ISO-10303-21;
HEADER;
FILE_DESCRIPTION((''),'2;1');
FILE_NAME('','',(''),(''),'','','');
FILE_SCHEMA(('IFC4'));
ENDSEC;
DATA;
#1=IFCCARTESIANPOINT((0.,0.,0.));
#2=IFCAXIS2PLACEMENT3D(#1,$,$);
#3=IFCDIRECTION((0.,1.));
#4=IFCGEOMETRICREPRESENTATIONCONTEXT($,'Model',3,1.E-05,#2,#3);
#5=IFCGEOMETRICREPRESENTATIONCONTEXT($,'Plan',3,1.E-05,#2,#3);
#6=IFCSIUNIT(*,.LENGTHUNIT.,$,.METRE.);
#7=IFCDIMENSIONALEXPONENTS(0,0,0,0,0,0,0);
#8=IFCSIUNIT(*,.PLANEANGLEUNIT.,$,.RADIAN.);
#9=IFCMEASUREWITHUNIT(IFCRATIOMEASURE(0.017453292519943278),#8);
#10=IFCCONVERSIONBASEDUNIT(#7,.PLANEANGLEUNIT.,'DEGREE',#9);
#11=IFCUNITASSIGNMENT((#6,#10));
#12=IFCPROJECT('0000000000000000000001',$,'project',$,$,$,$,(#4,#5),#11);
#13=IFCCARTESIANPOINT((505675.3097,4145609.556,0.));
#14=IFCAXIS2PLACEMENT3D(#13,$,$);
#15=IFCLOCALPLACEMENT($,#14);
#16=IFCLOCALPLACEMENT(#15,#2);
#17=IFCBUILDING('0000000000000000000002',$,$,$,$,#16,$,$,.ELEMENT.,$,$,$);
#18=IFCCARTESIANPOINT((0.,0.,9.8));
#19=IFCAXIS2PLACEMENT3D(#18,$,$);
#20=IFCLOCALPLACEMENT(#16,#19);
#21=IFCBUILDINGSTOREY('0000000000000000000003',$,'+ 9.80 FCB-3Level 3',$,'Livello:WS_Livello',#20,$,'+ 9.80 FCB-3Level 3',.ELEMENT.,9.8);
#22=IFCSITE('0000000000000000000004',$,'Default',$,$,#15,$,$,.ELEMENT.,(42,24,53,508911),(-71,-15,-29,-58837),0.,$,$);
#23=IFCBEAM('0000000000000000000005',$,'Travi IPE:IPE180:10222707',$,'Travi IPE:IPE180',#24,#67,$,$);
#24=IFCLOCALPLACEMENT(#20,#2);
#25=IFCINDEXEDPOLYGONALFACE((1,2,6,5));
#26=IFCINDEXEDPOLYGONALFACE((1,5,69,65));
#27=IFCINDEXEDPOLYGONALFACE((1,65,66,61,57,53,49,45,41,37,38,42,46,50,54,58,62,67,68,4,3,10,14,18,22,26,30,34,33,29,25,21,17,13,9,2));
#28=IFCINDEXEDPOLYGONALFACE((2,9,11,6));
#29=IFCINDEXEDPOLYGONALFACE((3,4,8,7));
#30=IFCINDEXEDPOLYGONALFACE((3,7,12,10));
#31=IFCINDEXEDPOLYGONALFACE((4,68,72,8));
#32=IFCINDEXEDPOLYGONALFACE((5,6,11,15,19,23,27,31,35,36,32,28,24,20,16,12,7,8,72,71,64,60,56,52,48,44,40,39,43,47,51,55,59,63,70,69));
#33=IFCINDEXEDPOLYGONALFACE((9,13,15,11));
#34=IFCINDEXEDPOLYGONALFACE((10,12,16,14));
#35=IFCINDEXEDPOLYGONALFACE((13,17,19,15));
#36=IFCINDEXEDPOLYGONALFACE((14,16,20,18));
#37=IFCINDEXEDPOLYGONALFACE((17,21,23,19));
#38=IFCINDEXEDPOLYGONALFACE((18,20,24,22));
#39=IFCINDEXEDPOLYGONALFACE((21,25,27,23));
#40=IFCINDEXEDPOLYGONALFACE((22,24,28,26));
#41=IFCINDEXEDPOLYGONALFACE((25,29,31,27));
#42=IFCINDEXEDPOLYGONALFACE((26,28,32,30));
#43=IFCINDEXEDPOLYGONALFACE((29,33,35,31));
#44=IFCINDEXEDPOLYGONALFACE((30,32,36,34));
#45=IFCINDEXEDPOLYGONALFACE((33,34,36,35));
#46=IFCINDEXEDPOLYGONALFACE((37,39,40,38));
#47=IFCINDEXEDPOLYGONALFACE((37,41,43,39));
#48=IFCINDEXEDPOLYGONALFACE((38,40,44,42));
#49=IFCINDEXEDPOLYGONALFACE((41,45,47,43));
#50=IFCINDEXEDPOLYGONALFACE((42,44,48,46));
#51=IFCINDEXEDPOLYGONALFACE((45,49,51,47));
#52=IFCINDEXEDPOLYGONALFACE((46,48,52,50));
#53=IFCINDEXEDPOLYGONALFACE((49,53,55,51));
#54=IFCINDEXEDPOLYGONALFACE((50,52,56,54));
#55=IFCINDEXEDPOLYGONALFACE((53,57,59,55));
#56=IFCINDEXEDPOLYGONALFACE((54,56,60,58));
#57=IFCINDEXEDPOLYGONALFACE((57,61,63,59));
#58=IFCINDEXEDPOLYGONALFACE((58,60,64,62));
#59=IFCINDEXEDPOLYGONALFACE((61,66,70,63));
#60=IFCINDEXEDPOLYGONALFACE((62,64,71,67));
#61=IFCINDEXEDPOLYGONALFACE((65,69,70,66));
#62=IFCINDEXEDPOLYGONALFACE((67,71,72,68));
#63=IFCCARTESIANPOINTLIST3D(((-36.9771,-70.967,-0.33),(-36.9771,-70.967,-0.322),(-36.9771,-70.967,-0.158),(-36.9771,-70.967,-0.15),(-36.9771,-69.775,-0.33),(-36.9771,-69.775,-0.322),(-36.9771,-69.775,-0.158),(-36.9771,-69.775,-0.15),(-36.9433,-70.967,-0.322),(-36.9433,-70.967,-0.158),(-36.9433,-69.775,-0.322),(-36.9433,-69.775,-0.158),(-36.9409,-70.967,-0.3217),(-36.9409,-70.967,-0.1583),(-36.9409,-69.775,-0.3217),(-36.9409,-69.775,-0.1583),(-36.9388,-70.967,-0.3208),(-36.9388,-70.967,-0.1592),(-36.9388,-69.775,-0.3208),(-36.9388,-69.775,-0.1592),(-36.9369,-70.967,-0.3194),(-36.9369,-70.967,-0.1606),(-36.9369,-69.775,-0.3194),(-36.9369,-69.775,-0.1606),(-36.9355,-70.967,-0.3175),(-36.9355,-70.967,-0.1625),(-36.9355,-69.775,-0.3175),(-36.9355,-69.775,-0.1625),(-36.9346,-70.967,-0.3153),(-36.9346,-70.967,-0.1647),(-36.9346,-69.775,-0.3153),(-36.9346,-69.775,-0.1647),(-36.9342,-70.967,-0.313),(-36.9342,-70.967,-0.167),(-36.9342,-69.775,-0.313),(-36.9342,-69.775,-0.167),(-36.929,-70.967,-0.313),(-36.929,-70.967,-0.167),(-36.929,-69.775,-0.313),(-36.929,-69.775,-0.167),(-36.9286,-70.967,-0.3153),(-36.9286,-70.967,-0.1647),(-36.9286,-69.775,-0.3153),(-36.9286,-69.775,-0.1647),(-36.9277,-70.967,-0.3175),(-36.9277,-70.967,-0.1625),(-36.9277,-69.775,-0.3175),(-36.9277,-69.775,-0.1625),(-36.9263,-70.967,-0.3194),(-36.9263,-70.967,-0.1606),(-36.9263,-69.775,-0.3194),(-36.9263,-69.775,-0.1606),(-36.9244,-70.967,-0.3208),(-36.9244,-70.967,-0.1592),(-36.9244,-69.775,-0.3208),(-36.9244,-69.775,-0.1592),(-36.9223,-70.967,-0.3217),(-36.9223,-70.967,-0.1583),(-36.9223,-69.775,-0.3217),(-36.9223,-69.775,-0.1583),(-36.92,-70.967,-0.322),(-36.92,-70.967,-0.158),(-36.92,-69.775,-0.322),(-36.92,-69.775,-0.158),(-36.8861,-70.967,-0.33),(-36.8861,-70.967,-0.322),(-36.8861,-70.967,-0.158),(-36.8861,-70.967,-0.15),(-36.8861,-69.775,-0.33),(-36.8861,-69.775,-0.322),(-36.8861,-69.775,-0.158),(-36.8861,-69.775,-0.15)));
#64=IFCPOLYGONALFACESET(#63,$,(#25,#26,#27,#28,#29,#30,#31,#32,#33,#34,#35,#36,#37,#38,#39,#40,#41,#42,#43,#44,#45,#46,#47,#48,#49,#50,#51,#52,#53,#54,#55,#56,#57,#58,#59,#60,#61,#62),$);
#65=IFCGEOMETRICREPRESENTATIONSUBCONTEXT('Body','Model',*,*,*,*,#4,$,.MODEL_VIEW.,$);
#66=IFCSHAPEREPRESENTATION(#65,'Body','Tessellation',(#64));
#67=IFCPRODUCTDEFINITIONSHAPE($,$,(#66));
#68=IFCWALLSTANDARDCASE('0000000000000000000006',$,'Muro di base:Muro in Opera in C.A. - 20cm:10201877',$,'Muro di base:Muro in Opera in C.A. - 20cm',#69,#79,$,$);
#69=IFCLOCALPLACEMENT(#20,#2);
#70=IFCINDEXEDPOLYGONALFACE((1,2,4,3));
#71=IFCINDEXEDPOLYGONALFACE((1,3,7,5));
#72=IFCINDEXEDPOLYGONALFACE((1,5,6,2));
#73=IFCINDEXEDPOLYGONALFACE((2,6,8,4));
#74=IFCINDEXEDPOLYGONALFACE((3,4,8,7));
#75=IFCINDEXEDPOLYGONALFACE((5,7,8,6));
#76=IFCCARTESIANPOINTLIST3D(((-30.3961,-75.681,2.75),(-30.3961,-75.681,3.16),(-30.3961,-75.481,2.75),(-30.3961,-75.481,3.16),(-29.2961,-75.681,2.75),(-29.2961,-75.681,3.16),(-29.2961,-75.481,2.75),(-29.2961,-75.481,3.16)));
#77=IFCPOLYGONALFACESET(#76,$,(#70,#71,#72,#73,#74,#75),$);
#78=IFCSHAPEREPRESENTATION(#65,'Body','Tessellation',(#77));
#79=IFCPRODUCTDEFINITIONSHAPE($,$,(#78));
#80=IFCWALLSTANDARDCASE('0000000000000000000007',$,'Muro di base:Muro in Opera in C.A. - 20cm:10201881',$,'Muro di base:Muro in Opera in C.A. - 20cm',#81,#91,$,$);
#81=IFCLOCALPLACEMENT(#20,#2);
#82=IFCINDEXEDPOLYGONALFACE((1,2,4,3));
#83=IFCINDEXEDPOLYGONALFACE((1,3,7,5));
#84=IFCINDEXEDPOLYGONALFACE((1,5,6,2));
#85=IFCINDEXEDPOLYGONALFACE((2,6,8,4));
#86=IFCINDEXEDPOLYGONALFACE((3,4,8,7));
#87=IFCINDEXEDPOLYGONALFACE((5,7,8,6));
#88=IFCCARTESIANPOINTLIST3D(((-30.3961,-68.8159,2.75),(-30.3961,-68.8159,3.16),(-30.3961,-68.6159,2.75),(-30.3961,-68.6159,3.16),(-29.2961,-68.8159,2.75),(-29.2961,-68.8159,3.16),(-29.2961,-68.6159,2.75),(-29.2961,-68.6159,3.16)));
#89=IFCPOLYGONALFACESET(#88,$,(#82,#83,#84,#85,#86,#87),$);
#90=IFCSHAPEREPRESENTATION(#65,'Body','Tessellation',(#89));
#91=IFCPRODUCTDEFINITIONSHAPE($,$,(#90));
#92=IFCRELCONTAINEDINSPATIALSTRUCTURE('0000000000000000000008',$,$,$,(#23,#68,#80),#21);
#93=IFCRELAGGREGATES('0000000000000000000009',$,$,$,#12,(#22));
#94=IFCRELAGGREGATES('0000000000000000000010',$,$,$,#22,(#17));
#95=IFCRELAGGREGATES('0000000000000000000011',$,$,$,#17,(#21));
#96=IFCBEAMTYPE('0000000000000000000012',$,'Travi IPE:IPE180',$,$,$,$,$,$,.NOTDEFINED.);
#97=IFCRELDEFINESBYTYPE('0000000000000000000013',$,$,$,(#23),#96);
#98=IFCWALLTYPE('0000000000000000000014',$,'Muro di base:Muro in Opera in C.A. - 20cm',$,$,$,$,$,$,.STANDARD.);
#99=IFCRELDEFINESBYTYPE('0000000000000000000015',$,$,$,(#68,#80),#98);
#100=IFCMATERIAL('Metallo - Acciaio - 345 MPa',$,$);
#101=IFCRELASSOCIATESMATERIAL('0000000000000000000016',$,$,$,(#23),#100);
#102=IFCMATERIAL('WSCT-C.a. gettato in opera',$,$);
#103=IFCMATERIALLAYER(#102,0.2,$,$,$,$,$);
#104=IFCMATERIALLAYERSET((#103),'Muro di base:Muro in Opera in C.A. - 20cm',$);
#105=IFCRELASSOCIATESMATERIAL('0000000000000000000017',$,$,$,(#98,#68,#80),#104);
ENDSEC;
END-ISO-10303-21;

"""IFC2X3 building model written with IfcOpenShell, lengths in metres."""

from ifc_helpers import new_model, entity, si_unit, converted_unit, direction, frame, frame_2d, origin, place, context, subcontext, project, spatial, rectangle, i_section, extrude, material, layer, layer_set, layer_usage, type_object, element, save


model = new_model("IFC2X3")

# Units and contexts
model_context = context("Model", 3, precision=1e-05, world=origin(), true_north=direction((0.0, 1.0)))
plan_context = context("Plan", 3, precision=1e-05, world=origin(), true_north=direction((0.0, 1.0)))
body_context = subcontext(model_context, "Body", "Model", "MODEL_VIEW")
ifc_project = project(units=[si_unit("LENGTHUNIT", "METRE"), converted_unit("PLANEANGLEUNIT", "DEGREE", entity("IfcRatioMeasure", 0.017453292519943278), si_unit("PLANEANGLEUNIT", "RADIAN"), dimensions=[0, 0, 0, 0, 0, 0, 0])], contexts=[model_context, plan_context])

# Site, building, storey
site_placement = place(None, frame((505675.3097, 4145609.556, 0.0)))
site = spatial("IfcSite", under=ifc_project, at=site_placement, Name="Default", CompositionType="ELEMENT", RefLatitude=(42, 24, 53, 508911), RefLongitude=(-71, -15, -29, -58837), RefElevation=0.0)
building_placement = place(site_placement, origin())
building = spatial("IfcBuilding", under=site, at=building_placement, CompositionType="ELEMENT")
storey_placement = place(building_placement, frame((0.0, 0.0, 9.8)))
storey = spatial("IfcBuildingStorey", under=building, at=storey_placement, Name="+ 9.80 FCB-3Level 3", ObjectType="Livello:WS_Livello", LongName="+ 9.80 FCB-3Level 3", CompositionType="ELEMENT", Elevation=9.8)

# Beam
ifc_material_1 = material(Name="Metallo - Acciaio - 345 MPa")
beam_type = type_object("IfcBeamType", Name="Travi IPE:IPE180", PredefinedType="NOTDEFINED")
beam_placement = place(storey_placement, frame((-36.9316, -69.7745, -0.15), z_axis=(0.0, 0.0, 1.0), x_axis=(0.0, -1.0, 0.0)))
element("IfcBeam", 1, at=beam_placement, inside=storey, type_object=beam_type, material=ifc_material_1, Name="Travi IPE:IPE180:10222707", ObjectType="Travi IPE:IPE180", context=body_context, shape_type="SweptSolid", body=[
    extrude(i_section(OverallWidth=0.091, OverallDepth=0.18, WebThickness=0.0053, FlangeThickness=0.008, FilletRadius=0.009, at=frame_2d((0.0, 0.0), x_axis=(0.0, 1.0))), frame((0.0005, 0.0, -0.09), z_axis=(1.0, 0.0, 0.0), x_axis=(0.0, 0.0, -1.0)), (0.0, 0.0, 1.0), 1.192),
])

# Walls
ifc_material_2 = material(Name="WSCT-C.a. gettato in opera")
ifc_layer_1 = layer(ifc_material_2, 0.2)
ifc_layer_set_1 = layer_set([ifc_layer_1], Name="Muro di base:Muro in Opera in C.A. - 20cm")
ifc_layer_usage_1 = layer_usage(ifc_layer_set_1, "AXIS2", "NEGATIVE", 0.1)
wall_type = type_object("IfcWallType", Name="Muro di base:Muro in Opera in C.A. - 20cm", PredefinedType="STANDARD", material=ifc_layer_set_1)
wall_1_placement = place(storey_placement, frame((-29.2961, -75.581, 2.75), z_axis=(0.0, 0.0, 1.0), x_axis=(-1.0, 0.0, 0.0)))
element("IfcWallStandardCase", 2, at=wall_1_placement, inside=storey, type_object=wall_type, material=ifc_layer_usage_1, Name="Muro di base:Muro in Opera in C.A. - 20cm:10201877", ObjectType="Muro di base:Muro in Opera in C.A. - 20cm", context=body_context, shape_type="SweptSolid", body=[
    extrude(rectangle(XDim=1.1, YDim=0.2, at=frame_2d((0.55, 0.0), x_axis=(-1.0, 0.0))), origin(), (0.0, 0.0, 1.0), 0.41),
])
wall_2_placement = place(storey_placement, frame((-30.3961, -68.7159, 2.75)))
element("IfcWallStandardCase", 3, at=wall_2_placement, inside=storey, type_object=wall_type, material=ifc_layer_usage_1, Name="Muro di base:Muro in Opera in C.A. - 20cm:10201881", ObjectType="Muro di base:Muro in Opera in C.A. - 20cm", context=body_context, shape_type="SweptSolid", body=[
    extrude(rectangle(XDim=1.1, YDim=0.2, at=frame_2d((0.55, 0.0), x_axis=(-1.0, 0.0))), origin(), (0.0, 0.0, 1.0), 0.41),
])

save(model, "model.ifc")
